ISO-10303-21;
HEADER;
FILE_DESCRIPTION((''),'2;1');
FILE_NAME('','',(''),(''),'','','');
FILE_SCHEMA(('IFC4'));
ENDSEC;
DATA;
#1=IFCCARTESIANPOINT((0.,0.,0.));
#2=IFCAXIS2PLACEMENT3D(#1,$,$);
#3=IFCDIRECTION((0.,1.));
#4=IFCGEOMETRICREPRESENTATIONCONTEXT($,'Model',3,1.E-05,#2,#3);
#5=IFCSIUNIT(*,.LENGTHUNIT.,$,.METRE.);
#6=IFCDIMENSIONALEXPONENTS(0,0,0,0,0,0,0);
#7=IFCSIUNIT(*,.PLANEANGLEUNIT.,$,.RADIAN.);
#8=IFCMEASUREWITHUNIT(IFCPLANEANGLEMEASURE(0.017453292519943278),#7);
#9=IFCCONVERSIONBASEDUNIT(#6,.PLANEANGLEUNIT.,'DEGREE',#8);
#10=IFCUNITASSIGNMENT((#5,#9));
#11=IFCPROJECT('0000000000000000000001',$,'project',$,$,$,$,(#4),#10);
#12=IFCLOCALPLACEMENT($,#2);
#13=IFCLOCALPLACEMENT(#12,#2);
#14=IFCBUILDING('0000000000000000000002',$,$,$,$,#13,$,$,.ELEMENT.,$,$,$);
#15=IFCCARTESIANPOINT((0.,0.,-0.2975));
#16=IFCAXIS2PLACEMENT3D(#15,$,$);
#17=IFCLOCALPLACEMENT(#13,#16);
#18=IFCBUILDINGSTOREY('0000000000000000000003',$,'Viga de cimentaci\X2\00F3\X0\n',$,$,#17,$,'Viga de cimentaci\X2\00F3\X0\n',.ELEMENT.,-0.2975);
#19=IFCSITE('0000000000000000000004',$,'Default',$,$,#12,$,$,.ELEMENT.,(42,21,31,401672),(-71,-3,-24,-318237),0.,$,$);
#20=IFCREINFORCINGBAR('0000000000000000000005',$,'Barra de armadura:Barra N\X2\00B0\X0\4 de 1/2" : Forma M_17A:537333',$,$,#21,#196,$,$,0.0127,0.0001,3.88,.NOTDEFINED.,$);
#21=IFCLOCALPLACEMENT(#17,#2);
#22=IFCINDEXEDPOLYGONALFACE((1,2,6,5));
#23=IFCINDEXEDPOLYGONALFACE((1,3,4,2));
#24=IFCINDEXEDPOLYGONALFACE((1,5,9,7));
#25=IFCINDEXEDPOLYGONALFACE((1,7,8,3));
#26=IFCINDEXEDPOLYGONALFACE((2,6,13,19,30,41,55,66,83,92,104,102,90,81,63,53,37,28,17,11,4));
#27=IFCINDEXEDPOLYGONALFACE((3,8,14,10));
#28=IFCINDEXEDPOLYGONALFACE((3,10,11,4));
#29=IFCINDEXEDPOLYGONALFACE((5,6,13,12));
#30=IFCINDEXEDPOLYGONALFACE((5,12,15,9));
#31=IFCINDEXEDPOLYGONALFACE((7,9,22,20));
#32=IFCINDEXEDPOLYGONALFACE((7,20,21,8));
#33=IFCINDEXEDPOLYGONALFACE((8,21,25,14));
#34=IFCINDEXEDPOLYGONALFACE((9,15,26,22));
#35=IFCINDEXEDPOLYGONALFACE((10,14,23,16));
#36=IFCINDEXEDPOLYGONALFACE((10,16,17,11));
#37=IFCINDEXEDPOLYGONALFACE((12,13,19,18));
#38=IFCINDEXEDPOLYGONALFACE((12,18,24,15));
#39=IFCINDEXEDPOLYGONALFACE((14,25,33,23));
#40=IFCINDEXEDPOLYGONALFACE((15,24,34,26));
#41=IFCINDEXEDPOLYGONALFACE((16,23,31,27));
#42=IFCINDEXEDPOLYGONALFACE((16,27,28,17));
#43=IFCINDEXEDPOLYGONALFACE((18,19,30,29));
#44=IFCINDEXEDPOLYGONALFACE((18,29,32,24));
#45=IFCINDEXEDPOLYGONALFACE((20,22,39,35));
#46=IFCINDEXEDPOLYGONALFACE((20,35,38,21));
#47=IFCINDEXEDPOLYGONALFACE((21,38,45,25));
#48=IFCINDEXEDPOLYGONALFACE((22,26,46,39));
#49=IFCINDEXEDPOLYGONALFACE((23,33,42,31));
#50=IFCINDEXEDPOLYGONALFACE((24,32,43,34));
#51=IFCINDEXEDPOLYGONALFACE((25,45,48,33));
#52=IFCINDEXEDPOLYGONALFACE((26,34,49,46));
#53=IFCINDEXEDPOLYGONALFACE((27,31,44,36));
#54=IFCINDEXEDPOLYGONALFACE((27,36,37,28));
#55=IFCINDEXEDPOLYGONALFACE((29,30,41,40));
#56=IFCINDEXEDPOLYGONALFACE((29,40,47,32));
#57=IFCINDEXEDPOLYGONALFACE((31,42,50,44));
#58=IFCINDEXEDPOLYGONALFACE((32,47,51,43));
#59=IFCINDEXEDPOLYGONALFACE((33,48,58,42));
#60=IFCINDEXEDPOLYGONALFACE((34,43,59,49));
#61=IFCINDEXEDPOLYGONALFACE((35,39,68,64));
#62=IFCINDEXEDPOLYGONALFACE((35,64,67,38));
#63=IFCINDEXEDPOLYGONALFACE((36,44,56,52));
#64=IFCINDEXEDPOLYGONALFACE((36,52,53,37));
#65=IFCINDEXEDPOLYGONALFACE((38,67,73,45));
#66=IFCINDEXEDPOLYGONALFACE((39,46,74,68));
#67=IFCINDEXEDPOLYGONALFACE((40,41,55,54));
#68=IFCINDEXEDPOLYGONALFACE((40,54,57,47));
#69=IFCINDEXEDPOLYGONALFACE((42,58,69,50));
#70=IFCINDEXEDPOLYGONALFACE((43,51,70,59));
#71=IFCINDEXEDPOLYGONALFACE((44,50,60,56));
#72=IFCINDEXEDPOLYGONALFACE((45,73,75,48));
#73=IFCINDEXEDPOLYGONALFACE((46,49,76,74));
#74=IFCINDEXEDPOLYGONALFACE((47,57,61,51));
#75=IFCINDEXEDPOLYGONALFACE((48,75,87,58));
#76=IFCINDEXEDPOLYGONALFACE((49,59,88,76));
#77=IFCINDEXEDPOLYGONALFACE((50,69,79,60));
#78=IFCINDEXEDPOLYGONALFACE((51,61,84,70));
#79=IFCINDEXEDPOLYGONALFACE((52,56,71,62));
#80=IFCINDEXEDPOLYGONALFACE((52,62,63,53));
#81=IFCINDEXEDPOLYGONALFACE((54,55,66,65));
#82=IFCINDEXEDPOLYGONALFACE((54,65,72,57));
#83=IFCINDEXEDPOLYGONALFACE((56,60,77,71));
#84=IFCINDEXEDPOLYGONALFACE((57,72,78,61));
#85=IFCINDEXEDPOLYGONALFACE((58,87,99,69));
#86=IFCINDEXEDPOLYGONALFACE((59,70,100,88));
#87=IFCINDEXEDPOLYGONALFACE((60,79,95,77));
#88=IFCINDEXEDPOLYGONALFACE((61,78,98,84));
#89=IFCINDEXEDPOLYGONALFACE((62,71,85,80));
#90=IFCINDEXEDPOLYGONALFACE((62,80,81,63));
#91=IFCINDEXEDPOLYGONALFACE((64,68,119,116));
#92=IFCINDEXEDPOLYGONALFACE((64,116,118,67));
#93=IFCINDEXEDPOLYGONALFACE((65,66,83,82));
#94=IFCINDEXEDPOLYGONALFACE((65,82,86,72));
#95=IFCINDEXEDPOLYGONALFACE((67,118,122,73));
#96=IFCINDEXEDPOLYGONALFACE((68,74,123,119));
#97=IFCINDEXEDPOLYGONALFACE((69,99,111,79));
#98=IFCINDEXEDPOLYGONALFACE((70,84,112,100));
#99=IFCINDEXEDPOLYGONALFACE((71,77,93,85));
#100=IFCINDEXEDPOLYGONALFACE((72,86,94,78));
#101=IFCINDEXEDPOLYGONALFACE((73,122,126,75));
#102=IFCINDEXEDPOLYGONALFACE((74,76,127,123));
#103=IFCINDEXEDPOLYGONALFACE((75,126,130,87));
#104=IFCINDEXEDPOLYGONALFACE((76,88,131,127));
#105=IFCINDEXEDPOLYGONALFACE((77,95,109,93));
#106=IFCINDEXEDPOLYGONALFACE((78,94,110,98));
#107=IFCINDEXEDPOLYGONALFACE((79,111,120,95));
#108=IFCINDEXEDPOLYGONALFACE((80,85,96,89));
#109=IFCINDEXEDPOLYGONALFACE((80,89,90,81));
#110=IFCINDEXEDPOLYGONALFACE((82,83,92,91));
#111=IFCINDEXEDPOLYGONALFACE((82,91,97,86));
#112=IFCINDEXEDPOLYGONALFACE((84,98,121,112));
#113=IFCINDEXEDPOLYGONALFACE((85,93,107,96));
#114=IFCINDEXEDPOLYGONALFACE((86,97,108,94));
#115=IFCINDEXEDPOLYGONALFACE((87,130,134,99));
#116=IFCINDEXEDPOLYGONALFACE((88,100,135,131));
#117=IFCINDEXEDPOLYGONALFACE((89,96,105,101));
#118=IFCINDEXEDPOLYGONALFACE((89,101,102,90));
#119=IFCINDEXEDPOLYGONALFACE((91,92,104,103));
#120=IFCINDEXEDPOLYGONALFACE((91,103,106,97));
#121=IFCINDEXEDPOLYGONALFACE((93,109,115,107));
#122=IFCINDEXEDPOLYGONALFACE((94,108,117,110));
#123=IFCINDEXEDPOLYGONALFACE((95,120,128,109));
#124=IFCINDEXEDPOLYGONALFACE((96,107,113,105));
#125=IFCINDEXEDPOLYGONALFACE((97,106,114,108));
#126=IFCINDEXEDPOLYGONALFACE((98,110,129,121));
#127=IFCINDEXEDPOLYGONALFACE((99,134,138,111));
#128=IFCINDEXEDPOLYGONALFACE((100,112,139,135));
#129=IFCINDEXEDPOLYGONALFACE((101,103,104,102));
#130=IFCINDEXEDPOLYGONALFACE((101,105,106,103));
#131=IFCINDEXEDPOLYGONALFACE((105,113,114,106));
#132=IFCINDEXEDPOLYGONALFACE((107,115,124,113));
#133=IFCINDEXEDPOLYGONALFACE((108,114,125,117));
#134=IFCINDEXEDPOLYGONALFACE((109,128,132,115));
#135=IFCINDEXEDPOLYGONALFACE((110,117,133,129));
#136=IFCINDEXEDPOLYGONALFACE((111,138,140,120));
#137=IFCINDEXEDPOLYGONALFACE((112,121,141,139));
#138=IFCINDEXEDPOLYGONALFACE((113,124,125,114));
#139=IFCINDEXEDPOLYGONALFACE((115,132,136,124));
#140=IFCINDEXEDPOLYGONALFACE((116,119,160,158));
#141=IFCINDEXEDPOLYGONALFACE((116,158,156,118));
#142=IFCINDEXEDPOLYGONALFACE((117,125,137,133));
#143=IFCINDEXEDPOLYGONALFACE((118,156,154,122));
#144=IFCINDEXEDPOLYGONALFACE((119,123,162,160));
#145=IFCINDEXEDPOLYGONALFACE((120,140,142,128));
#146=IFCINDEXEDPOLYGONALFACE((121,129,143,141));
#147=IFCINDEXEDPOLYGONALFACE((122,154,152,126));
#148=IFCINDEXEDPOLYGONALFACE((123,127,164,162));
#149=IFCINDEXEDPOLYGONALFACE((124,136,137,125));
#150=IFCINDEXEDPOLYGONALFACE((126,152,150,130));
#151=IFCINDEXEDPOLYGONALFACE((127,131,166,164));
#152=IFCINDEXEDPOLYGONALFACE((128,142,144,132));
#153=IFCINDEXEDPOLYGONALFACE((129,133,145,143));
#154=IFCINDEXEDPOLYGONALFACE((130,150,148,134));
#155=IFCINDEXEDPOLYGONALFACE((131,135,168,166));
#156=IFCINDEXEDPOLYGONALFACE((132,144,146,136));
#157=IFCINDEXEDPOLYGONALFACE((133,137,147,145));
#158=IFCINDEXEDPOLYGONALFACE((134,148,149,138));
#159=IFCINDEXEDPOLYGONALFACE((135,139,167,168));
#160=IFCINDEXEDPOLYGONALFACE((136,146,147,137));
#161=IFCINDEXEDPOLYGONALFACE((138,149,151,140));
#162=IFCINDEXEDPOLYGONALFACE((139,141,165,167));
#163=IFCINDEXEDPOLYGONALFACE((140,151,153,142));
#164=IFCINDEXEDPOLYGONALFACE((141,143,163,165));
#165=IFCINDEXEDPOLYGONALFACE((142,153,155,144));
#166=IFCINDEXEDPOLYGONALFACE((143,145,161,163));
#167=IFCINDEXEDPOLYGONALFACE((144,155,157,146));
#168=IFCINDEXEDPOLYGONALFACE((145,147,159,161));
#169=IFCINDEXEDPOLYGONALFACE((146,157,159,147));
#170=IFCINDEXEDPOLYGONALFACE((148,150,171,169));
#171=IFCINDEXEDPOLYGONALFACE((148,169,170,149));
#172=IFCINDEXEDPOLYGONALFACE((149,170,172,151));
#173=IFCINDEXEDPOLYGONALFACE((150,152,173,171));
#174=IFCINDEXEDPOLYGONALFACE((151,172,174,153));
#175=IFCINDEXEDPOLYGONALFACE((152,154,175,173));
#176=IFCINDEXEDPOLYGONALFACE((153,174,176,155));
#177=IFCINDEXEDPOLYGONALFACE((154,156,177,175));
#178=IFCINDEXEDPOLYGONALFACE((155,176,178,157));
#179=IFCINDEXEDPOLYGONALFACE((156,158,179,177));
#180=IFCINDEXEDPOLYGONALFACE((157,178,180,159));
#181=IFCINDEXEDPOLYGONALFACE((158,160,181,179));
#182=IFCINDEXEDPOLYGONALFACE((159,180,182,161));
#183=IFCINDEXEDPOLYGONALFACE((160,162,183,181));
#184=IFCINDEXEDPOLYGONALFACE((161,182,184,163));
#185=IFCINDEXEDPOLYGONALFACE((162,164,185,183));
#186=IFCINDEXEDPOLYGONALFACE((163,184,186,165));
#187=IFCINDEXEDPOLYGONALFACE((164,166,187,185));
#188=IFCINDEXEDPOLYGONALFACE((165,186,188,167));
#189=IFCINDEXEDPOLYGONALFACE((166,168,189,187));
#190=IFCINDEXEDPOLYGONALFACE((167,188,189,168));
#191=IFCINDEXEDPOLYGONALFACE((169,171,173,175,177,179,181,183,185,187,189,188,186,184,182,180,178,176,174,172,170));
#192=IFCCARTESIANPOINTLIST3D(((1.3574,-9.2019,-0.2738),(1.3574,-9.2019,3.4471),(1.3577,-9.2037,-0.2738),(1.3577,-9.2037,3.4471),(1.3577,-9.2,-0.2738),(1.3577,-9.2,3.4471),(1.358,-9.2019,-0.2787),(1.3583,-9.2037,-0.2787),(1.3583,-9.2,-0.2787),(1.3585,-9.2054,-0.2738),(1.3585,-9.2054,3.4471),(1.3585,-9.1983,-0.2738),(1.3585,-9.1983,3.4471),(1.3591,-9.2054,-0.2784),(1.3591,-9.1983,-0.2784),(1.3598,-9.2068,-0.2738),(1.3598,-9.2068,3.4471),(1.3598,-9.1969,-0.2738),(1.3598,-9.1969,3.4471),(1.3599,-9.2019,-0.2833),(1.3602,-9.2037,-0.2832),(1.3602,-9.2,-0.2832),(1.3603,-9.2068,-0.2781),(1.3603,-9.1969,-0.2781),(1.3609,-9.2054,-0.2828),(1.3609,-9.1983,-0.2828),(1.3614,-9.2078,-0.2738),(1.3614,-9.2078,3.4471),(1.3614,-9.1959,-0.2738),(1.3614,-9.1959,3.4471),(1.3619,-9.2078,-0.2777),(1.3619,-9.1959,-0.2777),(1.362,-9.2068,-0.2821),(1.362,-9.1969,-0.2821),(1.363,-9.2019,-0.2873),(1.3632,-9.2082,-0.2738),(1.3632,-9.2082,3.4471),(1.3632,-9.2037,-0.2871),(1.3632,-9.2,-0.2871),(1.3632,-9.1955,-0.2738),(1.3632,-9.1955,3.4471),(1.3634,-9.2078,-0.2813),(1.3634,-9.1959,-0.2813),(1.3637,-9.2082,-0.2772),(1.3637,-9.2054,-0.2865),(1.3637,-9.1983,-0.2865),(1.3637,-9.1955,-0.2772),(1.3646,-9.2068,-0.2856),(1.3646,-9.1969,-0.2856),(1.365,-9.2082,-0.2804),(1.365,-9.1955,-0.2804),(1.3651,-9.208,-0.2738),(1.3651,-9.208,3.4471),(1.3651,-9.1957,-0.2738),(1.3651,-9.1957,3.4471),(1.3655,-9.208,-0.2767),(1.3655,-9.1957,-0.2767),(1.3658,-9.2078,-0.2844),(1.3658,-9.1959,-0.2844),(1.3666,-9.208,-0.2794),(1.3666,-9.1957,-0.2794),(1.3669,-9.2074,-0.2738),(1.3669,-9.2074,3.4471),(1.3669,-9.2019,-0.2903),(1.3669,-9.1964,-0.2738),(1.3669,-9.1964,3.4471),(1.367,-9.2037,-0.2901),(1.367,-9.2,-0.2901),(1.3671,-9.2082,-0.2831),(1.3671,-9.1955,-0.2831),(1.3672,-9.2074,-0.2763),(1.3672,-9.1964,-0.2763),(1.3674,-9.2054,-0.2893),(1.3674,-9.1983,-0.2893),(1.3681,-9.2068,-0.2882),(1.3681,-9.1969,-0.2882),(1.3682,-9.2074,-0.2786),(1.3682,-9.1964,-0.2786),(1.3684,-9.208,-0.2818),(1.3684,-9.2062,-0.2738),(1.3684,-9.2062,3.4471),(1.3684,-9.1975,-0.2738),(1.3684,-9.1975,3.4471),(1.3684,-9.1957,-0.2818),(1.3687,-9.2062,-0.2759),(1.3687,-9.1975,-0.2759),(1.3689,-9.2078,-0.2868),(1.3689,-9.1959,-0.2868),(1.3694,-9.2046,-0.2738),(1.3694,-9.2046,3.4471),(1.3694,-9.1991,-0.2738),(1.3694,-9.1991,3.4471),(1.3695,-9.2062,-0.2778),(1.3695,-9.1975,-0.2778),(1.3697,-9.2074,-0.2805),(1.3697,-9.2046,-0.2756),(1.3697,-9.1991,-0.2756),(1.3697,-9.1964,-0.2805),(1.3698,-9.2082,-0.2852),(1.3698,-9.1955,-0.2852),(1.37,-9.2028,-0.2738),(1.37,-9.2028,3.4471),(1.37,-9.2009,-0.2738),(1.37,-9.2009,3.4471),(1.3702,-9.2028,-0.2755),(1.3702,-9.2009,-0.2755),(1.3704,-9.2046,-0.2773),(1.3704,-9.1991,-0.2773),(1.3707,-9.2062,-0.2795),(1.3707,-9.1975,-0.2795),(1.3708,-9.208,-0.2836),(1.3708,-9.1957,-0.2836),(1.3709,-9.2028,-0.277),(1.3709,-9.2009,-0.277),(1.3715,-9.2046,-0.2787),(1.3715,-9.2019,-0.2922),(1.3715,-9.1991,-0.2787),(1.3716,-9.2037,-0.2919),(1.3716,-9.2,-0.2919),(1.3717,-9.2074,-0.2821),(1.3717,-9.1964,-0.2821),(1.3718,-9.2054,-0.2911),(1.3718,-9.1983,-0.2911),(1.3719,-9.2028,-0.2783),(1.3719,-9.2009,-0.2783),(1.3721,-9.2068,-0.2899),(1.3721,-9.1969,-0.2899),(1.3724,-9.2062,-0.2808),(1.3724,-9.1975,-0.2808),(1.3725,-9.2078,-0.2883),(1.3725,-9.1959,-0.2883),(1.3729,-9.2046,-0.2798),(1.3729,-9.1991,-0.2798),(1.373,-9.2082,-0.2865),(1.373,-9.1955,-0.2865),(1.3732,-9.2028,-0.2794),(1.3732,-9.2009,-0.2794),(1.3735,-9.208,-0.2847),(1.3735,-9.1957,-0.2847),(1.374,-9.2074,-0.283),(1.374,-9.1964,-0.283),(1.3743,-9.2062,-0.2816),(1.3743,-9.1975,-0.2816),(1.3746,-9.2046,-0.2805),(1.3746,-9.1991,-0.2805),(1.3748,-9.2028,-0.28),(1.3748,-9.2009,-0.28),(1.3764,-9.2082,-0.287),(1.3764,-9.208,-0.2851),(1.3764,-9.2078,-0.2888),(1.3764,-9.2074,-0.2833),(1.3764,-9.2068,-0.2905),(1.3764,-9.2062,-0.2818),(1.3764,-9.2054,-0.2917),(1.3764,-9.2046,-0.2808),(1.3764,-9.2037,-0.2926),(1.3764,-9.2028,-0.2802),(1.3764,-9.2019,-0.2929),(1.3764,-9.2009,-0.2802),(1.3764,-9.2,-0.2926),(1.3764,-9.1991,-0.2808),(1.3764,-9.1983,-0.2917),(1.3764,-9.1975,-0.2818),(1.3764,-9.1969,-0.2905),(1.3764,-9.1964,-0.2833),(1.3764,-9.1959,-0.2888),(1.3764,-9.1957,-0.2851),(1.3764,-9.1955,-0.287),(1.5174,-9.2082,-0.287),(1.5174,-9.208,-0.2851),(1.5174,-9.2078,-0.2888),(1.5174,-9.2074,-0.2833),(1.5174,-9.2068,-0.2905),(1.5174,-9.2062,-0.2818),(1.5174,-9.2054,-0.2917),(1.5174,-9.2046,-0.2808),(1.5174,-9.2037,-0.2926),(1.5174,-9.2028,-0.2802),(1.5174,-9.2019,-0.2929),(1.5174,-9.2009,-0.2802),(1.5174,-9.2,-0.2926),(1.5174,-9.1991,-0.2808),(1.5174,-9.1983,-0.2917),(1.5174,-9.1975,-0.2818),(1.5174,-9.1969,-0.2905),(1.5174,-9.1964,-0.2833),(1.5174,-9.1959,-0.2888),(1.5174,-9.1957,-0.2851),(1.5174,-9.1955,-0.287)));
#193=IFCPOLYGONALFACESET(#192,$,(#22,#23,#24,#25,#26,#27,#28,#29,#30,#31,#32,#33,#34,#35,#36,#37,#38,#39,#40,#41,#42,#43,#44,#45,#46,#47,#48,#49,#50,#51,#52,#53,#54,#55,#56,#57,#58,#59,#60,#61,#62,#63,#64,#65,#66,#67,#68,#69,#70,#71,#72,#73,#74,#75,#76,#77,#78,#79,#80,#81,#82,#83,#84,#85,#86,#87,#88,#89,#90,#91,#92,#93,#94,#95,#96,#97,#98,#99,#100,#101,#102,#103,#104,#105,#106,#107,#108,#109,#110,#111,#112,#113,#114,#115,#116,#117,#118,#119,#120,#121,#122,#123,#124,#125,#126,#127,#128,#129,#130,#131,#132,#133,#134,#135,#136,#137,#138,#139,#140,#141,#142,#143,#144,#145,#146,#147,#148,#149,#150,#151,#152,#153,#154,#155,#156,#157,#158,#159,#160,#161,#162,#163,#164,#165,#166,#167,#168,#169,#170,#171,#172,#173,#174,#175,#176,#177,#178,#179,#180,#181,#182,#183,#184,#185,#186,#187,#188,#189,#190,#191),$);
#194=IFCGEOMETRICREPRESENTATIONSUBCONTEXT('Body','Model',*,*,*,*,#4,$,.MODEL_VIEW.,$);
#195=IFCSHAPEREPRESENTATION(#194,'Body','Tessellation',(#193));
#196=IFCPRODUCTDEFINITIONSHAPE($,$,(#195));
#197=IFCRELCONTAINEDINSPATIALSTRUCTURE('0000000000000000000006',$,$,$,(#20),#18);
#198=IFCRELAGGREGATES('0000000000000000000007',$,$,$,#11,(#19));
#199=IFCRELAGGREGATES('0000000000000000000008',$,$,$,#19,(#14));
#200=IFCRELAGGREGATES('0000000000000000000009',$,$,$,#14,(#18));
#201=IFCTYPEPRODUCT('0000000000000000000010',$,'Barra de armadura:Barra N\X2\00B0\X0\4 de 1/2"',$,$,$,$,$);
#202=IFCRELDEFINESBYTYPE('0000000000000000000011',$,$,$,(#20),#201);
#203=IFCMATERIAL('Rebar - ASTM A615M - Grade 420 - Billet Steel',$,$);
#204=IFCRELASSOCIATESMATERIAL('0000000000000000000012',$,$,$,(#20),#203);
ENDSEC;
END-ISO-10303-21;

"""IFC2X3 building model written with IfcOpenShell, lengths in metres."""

from ifc_helpers import new_model, entity, si_unit, converted_unit, direction, frame, origin, place, context, subcontext, project, spatial, material, type_object, element, save


model = new_model("IFC2X3")

# Units and contexts
model_context = context("Model", 3, precision=1e-05, world=origin(), true_north=direction((0.0, 1.0)))
body_context = subcontext(model_context, "Body", "Model", "MODEL_VIEW")
ifc_project = project(units=[si_unit("LENGTHUNIT", "METRE"), converted_unit("PLANEANGLEUNIT", "DEGREE", entity("IfcPlaneAngleMeasure", 0.017453292519943278), si_unit("PLANEANGLEUNIT", "RADIAN"), dimensions=[0, 0, 0, 0, 0, 0, 0])], contexts=[model_context])

# Site, building, storey
site_placement = place(None, origin())
site = spatial("IfcSite", under=ifc_project, at=site_placement, Name="Default", CompositionType="ELEMENT", RefLatitude=(42, 21, 31, 401672), RefLongitude=(-71, -3, -24, -318237), RefElevation=0.0)
building_placement = place(site_placement, origin())
building = spatial("IfcBuilding", under=site, at=building_placement, CompositionType="ELEMENT")
storey_placement = place(building_placement, frame((0.0, 0.0, -0.2975)))
storey = spatial("IfcBuildingStorey", under=building, at=storey_placement, Name="Viga de cimentación", LongName="Viga de cimentación", CompositionType="ELEMENT", Elevation=-0.2975)

# Reinforcing bar
ifc_material = material(Name="Rebar - ASTM A615M - Grade 420 - Billet Steel")
type_product_1 = type_object("IfcTypeProduct", Name="Barra de armadura:Barra N°4 de 1/2\"")
reinforcing_bar_1_placement = place(storey_placement, origin())
element("IfcReinforcingBar", 1, at=reinforcing_bar_1_placement, inside=storey, type_object=type_product_1, material=ifc_material, Name="Barra de armadura:Barra N°4 de 1/2\" : Forma M_17A:537333", BarLength=3.88, BarRole="NOTDEFINED", CrossSectionArea=0.0001, NominalDiameter=0.0127, context=body_context, shape_type="AdvancedSweptSolid", body=[
    entity("IfcSweptDiskSolid", entity("IfcCompositeCurve", [entity("IfcCompositeCurveSegment", "CONTINUOUS", True, entity("IfcPolyline", [entity("IfcCartesianPoint", [1.3637, -9.2019, 3.4471]), entity("IfcCartesianPoint", [1.3637, -9.2019, -0.2738])])), entity("IfcCompositeCurveSegment", "CONTINUOUS", True, entity("IfcTrimmedCurve", entity("IfcCircle", entity("IfcAxis2Placement3D", entity("IfcCartesianPoint", [1.3764, -9.2019, -0.2738]), entity("IfcDirection", [0.0, -1.0, 0.0]), entity("IfcDirection", [0.0, 0.0, -1.0])), 0.0127), [entity("IfcParameterValue", 270.0)], [entity("IfcParameterValue", 360.0)], True, "PARAMETER")), entity("IfcCompositeCurveSegment", "CONTINUOUS", True, entity("IfcPolyline", [entity("IfcCartesianPoint", [1.3764, -9.2019, -0.2865]), entity("IfcCartesianPoint", [1.5174, -9.2019, -0.2865])]))], False), 0.0063, None, 0.0, 92.0),
])

save(model, "model.ifc")
